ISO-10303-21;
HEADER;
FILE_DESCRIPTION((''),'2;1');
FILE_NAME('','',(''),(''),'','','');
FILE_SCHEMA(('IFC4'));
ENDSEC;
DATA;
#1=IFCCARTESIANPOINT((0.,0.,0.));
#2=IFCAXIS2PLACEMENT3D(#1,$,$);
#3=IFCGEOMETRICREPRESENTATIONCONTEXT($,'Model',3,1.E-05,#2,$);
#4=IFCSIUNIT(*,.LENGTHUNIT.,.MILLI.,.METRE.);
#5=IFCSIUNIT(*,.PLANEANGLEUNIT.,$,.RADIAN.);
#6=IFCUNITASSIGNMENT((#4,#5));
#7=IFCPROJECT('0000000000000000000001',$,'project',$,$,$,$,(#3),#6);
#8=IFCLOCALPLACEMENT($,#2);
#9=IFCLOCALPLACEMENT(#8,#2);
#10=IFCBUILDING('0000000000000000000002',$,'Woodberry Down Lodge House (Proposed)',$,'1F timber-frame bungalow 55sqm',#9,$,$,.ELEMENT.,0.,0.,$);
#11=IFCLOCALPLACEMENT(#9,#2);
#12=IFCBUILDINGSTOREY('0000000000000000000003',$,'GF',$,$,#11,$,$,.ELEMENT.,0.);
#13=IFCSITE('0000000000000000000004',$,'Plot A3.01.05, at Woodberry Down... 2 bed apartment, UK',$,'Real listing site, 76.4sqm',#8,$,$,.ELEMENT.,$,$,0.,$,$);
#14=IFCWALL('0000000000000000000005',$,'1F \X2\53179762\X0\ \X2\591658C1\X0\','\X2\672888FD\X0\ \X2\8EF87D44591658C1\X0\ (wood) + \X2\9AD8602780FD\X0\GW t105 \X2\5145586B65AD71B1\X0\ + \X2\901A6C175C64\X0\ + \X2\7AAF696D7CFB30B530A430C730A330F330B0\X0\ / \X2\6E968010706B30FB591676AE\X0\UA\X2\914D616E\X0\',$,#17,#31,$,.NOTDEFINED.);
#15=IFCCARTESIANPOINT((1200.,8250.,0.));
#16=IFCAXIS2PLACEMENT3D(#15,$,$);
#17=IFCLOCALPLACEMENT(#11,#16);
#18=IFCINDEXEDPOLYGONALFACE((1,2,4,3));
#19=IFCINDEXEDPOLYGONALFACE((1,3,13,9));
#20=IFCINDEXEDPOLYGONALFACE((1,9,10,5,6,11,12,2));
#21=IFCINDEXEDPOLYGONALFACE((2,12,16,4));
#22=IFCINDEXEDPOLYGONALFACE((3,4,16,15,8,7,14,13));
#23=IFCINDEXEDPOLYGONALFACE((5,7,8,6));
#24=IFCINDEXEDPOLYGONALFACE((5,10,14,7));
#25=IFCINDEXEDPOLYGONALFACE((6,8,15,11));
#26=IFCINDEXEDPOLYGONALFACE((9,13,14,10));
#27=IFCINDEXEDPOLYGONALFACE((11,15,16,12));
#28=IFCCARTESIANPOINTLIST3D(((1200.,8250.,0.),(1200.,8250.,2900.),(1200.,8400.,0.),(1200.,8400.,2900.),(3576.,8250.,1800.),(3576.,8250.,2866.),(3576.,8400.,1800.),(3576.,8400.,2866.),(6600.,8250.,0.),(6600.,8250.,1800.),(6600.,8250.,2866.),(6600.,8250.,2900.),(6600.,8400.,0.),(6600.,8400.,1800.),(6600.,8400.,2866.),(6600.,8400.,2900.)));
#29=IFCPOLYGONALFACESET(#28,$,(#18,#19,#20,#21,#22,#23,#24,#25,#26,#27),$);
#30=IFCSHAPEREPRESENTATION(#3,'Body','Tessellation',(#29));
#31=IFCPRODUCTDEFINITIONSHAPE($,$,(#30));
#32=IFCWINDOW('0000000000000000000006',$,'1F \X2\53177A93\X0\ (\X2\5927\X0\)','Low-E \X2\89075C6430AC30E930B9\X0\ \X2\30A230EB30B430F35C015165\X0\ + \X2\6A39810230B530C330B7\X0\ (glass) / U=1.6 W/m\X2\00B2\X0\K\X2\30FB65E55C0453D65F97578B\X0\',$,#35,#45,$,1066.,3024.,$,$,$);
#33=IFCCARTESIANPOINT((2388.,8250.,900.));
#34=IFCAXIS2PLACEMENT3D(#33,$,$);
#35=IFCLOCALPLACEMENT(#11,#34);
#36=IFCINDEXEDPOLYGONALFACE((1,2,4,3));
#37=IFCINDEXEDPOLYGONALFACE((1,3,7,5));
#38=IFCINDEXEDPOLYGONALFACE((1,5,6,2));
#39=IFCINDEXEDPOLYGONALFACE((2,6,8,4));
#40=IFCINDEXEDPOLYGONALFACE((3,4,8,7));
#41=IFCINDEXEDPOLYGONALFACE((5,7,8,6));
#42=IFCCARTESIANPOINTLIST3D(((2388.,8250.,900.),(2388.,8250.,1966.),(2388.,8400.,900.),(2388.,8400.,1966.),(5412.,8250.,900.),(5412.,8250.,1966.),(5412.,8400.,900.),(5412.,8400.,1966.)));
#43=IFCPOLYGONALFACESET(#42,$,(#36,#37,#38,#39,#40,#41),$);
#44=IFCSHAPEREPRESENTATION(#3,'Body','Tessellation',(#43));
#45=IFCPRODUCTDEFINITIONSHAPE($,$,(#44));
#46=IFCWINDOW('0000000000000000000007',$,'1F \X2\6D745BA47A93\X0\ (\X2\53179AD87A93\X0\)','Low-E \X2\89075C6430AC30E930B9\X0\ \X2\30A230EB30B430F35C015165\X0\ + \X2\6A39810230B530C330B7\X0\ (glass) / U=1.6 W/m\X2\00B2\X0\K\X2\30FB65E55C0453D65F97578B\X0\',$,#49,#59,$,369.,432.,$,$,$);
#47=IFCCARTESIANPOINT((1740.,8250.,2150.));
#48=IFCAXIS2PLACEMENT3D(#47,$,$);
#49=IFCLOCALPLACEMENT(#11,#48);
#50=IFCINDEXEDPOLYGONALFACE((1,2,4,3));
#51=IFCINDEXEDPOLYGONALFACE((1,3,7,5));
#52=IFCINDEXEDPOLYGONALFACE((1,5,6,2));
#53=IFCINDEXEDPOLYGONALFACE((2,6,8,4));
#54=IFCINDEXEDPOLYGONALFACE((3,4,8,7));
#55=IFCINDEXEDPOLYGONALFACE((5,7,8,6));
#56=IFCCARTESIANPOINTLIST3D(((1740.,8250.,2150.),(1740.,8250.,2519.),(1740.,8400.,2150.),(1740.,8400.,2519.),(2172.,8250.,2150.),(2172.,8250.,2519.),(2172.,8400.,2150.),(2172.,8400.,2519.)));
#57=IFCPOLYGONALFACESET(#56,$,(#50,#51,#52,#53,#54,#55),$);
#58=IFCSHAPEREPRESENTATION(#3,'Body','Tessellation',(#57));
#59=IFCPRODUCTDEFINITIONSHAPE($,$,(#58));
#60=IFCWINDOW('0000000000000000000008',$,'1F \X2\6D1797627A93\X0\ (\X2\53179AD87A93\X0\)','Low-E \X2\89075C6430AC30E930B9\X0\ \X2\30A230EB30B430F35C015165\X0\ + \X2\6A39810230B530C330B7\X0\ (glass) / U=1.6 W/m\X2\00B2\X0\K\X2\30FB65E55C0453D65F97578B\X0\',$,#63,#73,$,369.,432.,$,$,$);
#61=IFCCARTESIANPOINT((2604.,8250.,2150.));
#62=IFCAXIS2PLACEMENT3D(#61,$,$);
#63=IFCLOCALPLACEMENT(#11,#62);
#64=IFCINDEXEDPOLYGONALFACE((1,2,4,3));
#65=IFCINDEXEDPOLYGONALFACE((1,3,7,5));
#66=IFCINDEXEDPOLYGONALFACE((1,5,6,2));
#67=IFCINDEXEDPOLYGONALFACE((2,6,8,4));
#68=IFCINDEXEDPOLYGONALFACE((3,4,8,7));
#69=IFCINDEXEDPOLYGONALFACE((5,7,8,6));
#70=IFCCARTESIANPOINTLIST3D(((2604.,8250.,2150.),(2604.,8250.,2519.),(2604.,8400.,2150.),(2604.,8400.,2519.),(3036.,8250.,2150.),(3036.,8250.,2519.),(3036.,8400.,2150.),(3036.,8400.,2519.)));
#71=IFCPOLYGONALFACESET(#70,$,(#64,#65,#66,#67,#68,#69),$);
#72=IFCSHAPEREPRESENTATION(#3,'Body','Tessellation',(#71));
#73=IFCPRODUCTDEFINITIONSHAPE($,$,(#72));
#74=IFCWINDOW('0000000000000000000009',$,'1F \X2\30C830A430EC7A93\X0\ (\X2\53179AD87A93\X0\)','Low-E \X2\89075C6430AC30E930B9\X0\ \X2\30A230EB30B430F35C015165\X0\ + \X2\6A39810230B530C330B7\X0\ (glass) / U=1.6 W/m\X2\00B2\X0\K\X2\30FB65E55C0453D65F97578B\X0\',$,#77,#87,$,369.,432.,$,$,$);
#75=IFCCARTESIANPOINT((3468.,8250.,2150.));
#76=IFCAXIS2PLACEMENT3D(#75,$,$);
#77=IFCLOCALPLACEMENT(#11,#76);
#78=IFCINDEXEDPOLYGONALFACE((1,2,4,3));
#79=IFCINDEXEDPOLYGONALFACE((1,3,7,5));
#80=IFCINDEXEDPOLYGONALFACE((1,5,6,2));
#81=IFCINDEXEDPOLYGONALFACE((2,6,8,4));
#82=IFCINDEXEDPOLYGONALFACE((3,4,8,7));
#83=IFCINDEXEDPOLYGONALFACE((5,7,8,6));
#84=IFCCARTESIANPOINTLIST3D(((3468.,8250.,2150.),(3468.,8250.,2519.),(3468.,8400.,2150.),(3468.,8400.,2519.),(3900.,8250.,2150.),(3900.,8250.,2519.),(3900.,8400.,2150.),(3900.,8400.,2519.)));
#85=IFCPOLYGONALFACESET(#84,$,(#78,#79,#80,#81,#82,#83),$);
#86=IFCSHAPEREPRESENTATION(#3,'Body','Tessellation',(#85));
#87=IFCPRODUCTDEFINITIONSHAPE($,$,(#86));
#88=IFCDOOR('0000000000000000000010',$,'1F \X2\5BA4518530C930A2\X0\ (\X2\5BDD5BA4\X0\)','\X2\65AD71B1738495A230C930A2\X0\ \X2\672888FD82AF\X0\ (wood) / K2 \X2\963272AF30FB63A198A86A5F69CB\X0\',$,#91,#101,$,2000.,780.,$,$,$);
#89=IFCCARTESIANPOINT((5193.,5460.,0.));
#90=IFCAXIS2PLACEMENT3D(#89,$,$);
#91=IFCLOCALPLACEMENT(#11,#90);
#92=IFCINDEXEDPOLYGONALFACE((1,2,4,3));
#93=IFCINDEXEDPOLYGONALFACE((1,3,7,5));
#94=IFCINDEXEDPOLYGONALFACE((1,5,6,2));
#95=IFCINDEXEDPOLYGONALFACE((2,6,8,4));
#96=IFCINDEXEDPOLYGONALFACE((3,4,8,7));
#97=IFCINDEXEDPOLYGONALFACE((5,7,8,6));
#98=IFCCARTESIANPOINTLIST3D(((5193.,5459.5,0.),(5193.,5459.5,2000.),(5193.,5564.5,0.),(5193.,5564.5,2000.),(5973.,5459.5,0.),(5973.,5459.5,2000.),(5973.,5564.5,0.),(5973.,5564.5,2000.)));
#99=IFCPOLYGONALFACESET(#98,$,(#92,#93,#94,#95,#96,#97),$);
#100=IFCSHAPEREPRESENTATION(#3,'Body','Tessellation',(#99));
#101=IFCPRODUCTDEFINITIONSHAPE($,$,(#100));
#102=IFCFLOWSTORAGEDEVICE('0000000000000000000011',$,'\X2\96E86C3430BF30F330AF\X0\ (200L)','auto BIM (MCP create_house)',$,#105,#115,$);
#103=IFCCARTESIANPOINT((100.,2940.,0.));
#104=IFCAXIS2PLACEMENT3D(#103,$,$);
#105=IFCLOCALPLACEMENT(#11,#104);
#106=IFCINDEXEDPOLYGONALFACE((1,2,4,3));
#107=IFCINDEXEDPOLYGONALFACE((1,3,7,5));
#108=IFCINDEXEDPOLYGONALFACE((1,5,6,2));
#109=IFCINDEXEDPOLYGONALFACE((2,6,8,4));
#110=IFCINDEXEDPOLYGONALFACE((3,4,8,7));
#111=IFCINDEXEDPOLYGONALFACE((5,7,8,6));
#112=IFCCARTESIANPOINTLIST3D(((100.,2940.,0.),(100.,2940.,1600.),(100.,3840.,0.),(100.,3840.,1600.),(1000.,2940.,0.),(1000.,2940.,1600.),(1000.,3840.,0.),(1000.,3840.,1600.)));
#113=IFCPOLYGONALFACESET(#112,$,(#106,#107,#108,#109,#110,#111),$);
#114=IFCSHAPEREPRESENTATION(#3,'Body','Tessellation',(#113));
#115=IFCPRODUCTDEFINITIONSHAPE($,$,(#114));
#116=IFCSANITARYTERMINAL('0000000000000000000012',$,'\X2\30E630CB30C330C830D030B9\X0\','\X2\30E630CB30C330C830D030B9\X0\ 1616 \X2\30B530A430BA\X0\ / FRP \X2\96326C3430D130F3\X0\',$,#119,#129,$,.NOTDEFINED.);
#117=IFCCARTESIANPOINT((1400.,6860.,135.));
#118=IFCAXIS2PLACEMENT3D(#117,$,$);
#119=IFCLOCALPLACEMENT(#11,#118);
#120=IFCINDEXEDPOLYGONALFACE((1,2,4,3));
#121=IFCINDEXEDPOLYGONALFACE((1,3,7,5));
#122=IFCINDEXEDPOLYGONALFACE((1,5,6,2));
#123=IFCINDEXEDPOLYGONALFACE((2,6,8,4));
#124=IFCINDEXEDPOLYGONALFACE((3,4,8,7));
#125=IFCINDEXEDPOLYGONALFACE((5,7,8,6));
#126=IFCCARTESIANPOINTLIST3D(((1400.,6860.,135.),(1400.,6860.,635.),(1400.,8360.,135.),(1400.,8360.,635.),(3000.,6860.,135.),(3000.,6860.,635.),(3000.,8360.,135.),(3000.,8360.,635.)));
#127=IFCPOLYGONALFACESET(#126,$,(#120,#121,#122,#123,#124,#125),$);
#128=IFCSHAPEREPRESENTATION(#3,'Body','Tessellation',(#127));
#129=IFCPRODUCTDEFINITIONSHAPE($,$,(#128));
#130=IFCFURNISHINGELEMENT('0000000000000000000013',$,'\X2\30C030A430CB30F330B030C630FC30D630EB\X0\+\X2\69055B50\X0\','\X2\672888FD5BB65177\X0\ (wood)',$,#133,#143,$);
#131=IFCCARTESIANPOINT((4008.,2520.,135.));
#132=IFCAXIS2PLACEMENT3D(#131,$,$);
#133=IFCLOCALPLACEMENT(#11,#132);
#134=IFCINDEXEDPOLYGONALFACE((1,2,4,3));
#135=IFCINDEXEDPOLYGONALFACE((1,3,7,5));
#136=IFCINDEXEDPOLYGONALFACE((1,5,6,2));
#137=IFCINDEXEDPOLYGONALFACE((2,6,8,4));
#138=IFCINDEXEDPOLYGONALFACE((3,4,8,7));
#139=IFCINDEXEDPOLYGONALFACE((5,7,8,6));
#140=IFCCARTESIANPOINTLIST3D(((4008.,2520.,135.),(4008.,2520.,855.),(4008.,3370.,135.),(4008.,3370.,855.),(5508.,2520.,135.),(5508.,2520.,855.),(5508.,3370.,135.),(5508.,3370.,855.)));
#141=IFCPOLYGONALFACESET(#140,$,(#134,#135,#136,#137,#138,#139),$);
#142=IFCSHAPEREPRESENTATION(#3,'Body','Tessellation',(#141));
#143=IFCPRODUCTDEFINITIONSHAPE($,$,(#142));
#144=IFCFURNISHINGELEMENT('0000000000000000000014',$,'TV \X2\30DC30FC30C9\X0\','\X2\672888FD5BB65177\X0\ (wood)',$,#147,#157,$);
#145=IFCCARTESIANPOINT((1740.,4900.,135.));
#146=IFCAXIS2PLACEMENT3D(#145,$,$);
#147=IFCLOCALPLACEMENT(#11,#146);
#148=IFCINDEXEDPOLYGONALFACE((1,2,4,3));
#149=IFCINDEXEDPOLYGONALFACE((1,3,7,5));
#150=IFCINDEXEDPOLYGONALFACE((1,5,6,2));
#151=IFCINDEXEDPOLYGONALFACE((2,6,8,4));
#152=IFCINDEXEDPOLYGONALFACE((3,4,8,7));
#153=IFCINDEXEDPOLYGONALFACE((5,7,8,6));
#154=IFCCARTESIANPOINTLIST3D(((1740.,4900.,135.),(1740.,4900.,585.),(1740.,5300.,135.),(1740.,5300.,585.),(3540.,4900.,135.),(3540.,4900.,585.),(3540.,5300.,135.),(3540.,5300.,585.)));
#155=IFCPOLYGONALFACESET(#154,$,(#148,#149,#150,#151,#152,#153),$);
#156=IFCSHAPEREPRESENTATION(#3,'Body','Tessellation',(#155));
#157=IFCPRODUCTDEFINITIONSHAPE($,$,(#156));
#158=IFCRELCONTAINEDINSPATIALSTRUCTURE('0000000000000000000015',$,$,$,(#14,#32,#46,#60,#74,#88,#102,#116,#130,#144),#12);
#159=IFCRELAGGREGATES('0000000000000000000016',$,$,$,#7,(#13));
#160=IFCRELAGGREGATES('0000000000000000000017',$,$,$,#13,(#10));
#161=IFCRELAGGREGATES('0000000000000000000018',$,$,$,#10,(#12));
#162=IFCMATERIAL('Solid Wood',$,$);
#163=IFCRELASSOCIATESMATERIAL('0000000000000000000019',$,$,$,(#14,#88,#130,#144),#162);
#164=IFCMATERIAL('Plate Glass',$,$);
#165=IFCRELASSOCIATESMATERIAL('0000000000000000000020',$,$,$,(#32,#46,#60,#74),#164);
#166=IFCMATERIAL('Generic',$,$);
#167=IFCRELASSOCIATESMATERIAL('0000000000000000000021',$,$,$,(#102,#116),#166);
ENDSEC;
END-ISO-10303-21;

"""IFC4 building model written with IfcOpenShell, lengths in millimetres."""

from ifc_helpers import new_model, si_unit, frame, frame_2d, origin, place, context, project, spatial, rectangle, extrude, material, element, fill, save


model = new_model("IFC4")

# Units and contexts
model_context = context("Model", 3, precision=1e-05, world=origin())
ifc_project = project(units=[si_unit("LENGTHUNIT", "METRE", prefix="MILLI"), si_unit("PLANEANGLEUNIT", "RADIAN")], contexts=[model_context])

# Site, building, storey
site_placement = place(None, origin())
site = spatial("IfcSite", under=ifc_project, at=site_placement, Name="Plot A3.01.05, at Woodberry Down... 2 bed apartment, UK", ObjectType="Real listing site, 76.4sqm", CompositionType="ELEMENT", RefElevation=0.0)
building_placement = place(site_placement, origin())
building = spatial("IfcBuilding", under=site, at=building_placement, Name="Woodberry Down Lodge House (Proposed)", ObjectType="1F timber-frame bungalow 55sqm", CompositionType="ELEMENT", ElevationOfRefHeight=0.0, ElevationOfTerrain=0.0)
storey_placement = place(building_placement, origin())
storey = spatial("IfcBuildingStorey", under=building, at=storey_placement, Name="GF", CompositionType="ELEMENT", Elevation=0.0)

# Wall, openings, windows
ifc_material_1 = material(Name="Solid Wood")
wall_1_placement = place(storey_placement, frame((1200.0, 8250.0, 0.0)))
wall_1 = element("IfcWall", 1, at=wall_1_placement, inside=storey, material=ifc_material_1, Name="1F 北面 外壁", Description="木製 軸組外壁 (wood) + 高性能GW t105 充填断熱 + 通気層 + 窯業系サイディング / 準耐火・外皮UA配慮", PredefinedType="NOTDEFINED", context=model_context, shape_type="SweptSolid", body=[
    extrude(rectangle(XDim=5400.0, YDim=150.0, at=frame_2d((2700.0, 75.0))), frame((1200.0, 8250.0, 0.0)), (0.0, 0.0, 1.0), 2900.0),
])
opening_1_placement = place(storey_placement, frame((2388.0, 8250.0, 900.0)))
opening_1 = element("IfcOpeningElement", 2, at=opening_1_placement, cuts=wall_1, PredefinedType="NOTDEFINED", context=model_context, shape_type="SweptSolid", body=[
    extrude(rectangle(XDim=3024.0, YDim=150.0, at=frame_2d((1512.0, 75.0))), frame((2388.0, 8250.0, 900.0)), (0.0, 0.0, 1.0), 1066.0),
])
opening_2_placement = place(storey_placement, frame((1740.0, 8250.0, 2150.0)))
opening_2 = element("IfcOpeningElement", 3, at=opening_2_placement, cuts=wall_1, PredefinedType="NOTDEFINED", context=model_context, shape_type="SweptSolid", body=[
    extrude(rectangle(XDim=432.0, YDim=150.0, at=frame_2d((216.0, 75.0))), frame((1740.0, 8250.0, 2150.0)), (0.0, 0.0, 1.0), 369.0),
])
opening_3_placement = place(storey_placement, frame((2604.0, 8250.0, 2150.0)))
opening_3 = element("IfcOpeningElement", 4, at=opening_3_placement, cuts=wall_1, PredefinedType="NOTDEFINED", context=model_context, shape_type="SweptSolid", body=[
    extrude(rectangle(XDim=432.0, YDim=150.0, at=frame_2d((216.0, 75.0))), frame((2604.0, 8250.0, 2150.0)), (0.0, 0.0, 1.0), 369.0),
])
opening_4_placement = place(storey_placement, frame((3468.0, 8250.0, 2150.0)))
opening_4 = element("IfcOpeningElement", 5, at=opening_4_placement, cuts=wall_1, PredefinedType="NOTDEFINED", context=model_context, shape_type="SweptSolid", body=[
    extrude(rectangle(XDim=432.0, YDim=150.0, at=frame_2d((216.0, 75.0))), frame((3468.0, 8250.0, 2150.0)), (0.0, 0.0, 1.0), 369.0),
])
ifc_material_2 = material(Name="Plate Glass")
window_1_placement = place(storey_placement, frame((2388.0, 8250.0, 900.0)))
window_1 = element("IfcWindow", 6, at=window_1_placement, inside=storey, material=ifc_material_2, Name="1F 北窓 (大)", Description="Low-E 複層ガラス アルゴン封入 + 樹脂サッシ (glass) / U=1.6 W/m²K・日射取得型", OverallHeight=1066.0, OverallWidth=3024.0, context=model_context, shape_type="SweptSolid", body=[
    extrude(rectangle(XDim=3024.0, YDim=150.0, at=frame_2d((1512.0, 75.0))), frame((2388.0, 8250.0, 900.0)), (0.0, 0.0, 1.0), 1066.0),
])
fill(opening_1, window_1)
window_2_placement = place(storey_placement, frame((1740.0, 8250.0, 2150.0)))
window_2 = element("IfcWindow", 7, at=window_2_placement, inside=storey, material=ifc_material_2, Name="1F 浴室窓 (北高窓)", Description="Low-E 複層ガラス アルゴン封入 + 樹脂サッシ (glass) / U=1.6 W/m²K・日射取得型", OverallHeight=369.0, OverallWidth=432.0, context=model_context, shape_type="SweptSolid", body=[
    extrude(rectangle(XDim=432.0, YDim=150.0, at=frame_2d((216.0, 75.0))), frame((1740.0, 8250.0, 2150.0)), (0.0, 0.0, 1.0), 369.0),
])
fill(opening_2, window_2)
window_3_placement = place(storey_placement, frame((2604.0, 8250.0, 2150.0)))
window_3 = element("IfcWindow", 8, at=window_3_placement, inside=storey, material=ifc_material_2, Name="1F 洗面窓 (北高窓)", Description="Low-E 複層ガラス アルゴン封入 + 樹脂サッシ (glass) / U=1.6 W/m²K・日射取得型", OverallHeight=369.0, OverallWidth=432.0, context=model_context, shape_type="SweptSolid", body=[
    extrude(rectangle(XDim=432.0, YDim=150.0, at=frame_2d((216.0, 75.0))), frame((2604.0, 8250.0, 2150.0)), (0.0, 0.0, 1.0), 369.0),
])
fill(opening_3, window_3)
window_4_placement = place(storey_placement, frame((3468.0, 8250.0, 2150.0)))
window_4 = element("IfcWindow", 9, at=window_4_placement, inside=storey, material=ifc_material_2, Name="1F トイレ窓 (北高窓)", Description="Low-E 複層ガラス アルゴン封入 + 樹脂サッシ (glass) / U=1.6 W/m²K・日射取得型", OverallHeight=369.0, OverallWidth=432.0, context=model_context, shape_type="SweptSolid", body=[
    extrude(rectangle(XDim=432.0, YDim=150.0, at=frame_2d((216.0, 75.0))), frame((3468.0, 8250.0, 2150.0)), (0.0, 0.0, 1.0), 369.0),
])
fill(opening_4, window_4)

# Door
door_1_placement = place(storey_placement, frame((5193.0, 5460.0, 0.0)))
element("IfcDoor", 10, at=door_1_placement, inside=storey, material=ifc_material_1, Name="1F 室内ドア (寝室)", Description="断熱玄関ドア 木製芯 (wood) / K2 防犯・採風機構", OverallHeight=2000.0, OverallWidth=780.0, context=model_context, shape_type="SweptSolid", body=[
    extrude(rectangle(XDim=780.0, YDim=105.0, at=frame_2d((390.0, 52.0))), frame((5193.0, 5460.0, 0.0)), (0.0, 0.0, 1.0), 2000.0),
])

# Flow storage device
ifc_material_3 = material(Name="Generic")
flow_storage_device_placement = place(storey_placement, frame((100.0, 2940.0, 0.0)))
element("IfcFlowStorageDevice", 11, at=flow_storage_device_placement, inside=storey, material=ifc_material_3, Name="雨水タンク (200L)", Description="auto BIM (MCP create_house)", context=model_context, shape_type="SweptSolid", body=[
    extrude(rectangle(XDim=900.0, YDim=900.0, at=frame_2d((450.0, 450.0))), frame((100.0, 2940.0, 0.0)), (0.0, 0.0, 1.0), 1600.0),
])

# Sanitary terminal
sanitary_terminal_placement = place(storey_placement, frame((1400.0, 6860.0, 135.0)))
element("IfcSanitaryTerminal", 12, at=sanitary_terminal_placement, inside=storey, material=ifc_material_3, Name="ユニットバス", Description="ユニットバス 1616 サイズ / FRP 防水パン", PredefinedType="NOTDEFINED", context=model_context, shape_type="SweptSolid", body=[
    extrude(rectangle(XDim=1600.0, YDim=1500.0, at=frame_2d((800.0, 750.0))), frame((1400.0, 6860.0, 135.0)), (0.0, 0.0, 1.0), 500.0),
])

# Furnishing elements
furnishing_1_placement = place(storey_placement, frame((4008.0, 2520.0, 135.0)))
element("IfcFurnishingElement", 13, at=furnishing_1_placement, inside=storey, material=ifc_material_1, Name="ダイニングテーブル+椅子", Description="木製家具 (wood)", context=model_context, shape_type="SweptSolid", body=[
    extrude(rectangle(XDim=1500.0, YDim=850.0, at=frame_2d((750.0, 425.0))), frame((4008.0, 2520.0, 135.0)), (0.0, 0.0, 1.0), 720.0),
])
furnishing_2_placement = place(storey_placement, frame((1740.0, 4900.0, 135.0)))
element("IfcFurnishingElement", 14, at=furnishing_2_placement, inside=storey, material=ifc_material_1, Name="TV ボード", Description="木製家具 (wood)", context=model_context, shape_type="SweptSolid", body=[
    extrude(rectangle(XDim=1800.0, YDim=400.0, at=frame_2d((900.0, 200.0))), frame((1740.0, 4900.0, 135.0)), (0.0, 0.0, 1.0), 450.0),
])

save(model, "model.ifc")
